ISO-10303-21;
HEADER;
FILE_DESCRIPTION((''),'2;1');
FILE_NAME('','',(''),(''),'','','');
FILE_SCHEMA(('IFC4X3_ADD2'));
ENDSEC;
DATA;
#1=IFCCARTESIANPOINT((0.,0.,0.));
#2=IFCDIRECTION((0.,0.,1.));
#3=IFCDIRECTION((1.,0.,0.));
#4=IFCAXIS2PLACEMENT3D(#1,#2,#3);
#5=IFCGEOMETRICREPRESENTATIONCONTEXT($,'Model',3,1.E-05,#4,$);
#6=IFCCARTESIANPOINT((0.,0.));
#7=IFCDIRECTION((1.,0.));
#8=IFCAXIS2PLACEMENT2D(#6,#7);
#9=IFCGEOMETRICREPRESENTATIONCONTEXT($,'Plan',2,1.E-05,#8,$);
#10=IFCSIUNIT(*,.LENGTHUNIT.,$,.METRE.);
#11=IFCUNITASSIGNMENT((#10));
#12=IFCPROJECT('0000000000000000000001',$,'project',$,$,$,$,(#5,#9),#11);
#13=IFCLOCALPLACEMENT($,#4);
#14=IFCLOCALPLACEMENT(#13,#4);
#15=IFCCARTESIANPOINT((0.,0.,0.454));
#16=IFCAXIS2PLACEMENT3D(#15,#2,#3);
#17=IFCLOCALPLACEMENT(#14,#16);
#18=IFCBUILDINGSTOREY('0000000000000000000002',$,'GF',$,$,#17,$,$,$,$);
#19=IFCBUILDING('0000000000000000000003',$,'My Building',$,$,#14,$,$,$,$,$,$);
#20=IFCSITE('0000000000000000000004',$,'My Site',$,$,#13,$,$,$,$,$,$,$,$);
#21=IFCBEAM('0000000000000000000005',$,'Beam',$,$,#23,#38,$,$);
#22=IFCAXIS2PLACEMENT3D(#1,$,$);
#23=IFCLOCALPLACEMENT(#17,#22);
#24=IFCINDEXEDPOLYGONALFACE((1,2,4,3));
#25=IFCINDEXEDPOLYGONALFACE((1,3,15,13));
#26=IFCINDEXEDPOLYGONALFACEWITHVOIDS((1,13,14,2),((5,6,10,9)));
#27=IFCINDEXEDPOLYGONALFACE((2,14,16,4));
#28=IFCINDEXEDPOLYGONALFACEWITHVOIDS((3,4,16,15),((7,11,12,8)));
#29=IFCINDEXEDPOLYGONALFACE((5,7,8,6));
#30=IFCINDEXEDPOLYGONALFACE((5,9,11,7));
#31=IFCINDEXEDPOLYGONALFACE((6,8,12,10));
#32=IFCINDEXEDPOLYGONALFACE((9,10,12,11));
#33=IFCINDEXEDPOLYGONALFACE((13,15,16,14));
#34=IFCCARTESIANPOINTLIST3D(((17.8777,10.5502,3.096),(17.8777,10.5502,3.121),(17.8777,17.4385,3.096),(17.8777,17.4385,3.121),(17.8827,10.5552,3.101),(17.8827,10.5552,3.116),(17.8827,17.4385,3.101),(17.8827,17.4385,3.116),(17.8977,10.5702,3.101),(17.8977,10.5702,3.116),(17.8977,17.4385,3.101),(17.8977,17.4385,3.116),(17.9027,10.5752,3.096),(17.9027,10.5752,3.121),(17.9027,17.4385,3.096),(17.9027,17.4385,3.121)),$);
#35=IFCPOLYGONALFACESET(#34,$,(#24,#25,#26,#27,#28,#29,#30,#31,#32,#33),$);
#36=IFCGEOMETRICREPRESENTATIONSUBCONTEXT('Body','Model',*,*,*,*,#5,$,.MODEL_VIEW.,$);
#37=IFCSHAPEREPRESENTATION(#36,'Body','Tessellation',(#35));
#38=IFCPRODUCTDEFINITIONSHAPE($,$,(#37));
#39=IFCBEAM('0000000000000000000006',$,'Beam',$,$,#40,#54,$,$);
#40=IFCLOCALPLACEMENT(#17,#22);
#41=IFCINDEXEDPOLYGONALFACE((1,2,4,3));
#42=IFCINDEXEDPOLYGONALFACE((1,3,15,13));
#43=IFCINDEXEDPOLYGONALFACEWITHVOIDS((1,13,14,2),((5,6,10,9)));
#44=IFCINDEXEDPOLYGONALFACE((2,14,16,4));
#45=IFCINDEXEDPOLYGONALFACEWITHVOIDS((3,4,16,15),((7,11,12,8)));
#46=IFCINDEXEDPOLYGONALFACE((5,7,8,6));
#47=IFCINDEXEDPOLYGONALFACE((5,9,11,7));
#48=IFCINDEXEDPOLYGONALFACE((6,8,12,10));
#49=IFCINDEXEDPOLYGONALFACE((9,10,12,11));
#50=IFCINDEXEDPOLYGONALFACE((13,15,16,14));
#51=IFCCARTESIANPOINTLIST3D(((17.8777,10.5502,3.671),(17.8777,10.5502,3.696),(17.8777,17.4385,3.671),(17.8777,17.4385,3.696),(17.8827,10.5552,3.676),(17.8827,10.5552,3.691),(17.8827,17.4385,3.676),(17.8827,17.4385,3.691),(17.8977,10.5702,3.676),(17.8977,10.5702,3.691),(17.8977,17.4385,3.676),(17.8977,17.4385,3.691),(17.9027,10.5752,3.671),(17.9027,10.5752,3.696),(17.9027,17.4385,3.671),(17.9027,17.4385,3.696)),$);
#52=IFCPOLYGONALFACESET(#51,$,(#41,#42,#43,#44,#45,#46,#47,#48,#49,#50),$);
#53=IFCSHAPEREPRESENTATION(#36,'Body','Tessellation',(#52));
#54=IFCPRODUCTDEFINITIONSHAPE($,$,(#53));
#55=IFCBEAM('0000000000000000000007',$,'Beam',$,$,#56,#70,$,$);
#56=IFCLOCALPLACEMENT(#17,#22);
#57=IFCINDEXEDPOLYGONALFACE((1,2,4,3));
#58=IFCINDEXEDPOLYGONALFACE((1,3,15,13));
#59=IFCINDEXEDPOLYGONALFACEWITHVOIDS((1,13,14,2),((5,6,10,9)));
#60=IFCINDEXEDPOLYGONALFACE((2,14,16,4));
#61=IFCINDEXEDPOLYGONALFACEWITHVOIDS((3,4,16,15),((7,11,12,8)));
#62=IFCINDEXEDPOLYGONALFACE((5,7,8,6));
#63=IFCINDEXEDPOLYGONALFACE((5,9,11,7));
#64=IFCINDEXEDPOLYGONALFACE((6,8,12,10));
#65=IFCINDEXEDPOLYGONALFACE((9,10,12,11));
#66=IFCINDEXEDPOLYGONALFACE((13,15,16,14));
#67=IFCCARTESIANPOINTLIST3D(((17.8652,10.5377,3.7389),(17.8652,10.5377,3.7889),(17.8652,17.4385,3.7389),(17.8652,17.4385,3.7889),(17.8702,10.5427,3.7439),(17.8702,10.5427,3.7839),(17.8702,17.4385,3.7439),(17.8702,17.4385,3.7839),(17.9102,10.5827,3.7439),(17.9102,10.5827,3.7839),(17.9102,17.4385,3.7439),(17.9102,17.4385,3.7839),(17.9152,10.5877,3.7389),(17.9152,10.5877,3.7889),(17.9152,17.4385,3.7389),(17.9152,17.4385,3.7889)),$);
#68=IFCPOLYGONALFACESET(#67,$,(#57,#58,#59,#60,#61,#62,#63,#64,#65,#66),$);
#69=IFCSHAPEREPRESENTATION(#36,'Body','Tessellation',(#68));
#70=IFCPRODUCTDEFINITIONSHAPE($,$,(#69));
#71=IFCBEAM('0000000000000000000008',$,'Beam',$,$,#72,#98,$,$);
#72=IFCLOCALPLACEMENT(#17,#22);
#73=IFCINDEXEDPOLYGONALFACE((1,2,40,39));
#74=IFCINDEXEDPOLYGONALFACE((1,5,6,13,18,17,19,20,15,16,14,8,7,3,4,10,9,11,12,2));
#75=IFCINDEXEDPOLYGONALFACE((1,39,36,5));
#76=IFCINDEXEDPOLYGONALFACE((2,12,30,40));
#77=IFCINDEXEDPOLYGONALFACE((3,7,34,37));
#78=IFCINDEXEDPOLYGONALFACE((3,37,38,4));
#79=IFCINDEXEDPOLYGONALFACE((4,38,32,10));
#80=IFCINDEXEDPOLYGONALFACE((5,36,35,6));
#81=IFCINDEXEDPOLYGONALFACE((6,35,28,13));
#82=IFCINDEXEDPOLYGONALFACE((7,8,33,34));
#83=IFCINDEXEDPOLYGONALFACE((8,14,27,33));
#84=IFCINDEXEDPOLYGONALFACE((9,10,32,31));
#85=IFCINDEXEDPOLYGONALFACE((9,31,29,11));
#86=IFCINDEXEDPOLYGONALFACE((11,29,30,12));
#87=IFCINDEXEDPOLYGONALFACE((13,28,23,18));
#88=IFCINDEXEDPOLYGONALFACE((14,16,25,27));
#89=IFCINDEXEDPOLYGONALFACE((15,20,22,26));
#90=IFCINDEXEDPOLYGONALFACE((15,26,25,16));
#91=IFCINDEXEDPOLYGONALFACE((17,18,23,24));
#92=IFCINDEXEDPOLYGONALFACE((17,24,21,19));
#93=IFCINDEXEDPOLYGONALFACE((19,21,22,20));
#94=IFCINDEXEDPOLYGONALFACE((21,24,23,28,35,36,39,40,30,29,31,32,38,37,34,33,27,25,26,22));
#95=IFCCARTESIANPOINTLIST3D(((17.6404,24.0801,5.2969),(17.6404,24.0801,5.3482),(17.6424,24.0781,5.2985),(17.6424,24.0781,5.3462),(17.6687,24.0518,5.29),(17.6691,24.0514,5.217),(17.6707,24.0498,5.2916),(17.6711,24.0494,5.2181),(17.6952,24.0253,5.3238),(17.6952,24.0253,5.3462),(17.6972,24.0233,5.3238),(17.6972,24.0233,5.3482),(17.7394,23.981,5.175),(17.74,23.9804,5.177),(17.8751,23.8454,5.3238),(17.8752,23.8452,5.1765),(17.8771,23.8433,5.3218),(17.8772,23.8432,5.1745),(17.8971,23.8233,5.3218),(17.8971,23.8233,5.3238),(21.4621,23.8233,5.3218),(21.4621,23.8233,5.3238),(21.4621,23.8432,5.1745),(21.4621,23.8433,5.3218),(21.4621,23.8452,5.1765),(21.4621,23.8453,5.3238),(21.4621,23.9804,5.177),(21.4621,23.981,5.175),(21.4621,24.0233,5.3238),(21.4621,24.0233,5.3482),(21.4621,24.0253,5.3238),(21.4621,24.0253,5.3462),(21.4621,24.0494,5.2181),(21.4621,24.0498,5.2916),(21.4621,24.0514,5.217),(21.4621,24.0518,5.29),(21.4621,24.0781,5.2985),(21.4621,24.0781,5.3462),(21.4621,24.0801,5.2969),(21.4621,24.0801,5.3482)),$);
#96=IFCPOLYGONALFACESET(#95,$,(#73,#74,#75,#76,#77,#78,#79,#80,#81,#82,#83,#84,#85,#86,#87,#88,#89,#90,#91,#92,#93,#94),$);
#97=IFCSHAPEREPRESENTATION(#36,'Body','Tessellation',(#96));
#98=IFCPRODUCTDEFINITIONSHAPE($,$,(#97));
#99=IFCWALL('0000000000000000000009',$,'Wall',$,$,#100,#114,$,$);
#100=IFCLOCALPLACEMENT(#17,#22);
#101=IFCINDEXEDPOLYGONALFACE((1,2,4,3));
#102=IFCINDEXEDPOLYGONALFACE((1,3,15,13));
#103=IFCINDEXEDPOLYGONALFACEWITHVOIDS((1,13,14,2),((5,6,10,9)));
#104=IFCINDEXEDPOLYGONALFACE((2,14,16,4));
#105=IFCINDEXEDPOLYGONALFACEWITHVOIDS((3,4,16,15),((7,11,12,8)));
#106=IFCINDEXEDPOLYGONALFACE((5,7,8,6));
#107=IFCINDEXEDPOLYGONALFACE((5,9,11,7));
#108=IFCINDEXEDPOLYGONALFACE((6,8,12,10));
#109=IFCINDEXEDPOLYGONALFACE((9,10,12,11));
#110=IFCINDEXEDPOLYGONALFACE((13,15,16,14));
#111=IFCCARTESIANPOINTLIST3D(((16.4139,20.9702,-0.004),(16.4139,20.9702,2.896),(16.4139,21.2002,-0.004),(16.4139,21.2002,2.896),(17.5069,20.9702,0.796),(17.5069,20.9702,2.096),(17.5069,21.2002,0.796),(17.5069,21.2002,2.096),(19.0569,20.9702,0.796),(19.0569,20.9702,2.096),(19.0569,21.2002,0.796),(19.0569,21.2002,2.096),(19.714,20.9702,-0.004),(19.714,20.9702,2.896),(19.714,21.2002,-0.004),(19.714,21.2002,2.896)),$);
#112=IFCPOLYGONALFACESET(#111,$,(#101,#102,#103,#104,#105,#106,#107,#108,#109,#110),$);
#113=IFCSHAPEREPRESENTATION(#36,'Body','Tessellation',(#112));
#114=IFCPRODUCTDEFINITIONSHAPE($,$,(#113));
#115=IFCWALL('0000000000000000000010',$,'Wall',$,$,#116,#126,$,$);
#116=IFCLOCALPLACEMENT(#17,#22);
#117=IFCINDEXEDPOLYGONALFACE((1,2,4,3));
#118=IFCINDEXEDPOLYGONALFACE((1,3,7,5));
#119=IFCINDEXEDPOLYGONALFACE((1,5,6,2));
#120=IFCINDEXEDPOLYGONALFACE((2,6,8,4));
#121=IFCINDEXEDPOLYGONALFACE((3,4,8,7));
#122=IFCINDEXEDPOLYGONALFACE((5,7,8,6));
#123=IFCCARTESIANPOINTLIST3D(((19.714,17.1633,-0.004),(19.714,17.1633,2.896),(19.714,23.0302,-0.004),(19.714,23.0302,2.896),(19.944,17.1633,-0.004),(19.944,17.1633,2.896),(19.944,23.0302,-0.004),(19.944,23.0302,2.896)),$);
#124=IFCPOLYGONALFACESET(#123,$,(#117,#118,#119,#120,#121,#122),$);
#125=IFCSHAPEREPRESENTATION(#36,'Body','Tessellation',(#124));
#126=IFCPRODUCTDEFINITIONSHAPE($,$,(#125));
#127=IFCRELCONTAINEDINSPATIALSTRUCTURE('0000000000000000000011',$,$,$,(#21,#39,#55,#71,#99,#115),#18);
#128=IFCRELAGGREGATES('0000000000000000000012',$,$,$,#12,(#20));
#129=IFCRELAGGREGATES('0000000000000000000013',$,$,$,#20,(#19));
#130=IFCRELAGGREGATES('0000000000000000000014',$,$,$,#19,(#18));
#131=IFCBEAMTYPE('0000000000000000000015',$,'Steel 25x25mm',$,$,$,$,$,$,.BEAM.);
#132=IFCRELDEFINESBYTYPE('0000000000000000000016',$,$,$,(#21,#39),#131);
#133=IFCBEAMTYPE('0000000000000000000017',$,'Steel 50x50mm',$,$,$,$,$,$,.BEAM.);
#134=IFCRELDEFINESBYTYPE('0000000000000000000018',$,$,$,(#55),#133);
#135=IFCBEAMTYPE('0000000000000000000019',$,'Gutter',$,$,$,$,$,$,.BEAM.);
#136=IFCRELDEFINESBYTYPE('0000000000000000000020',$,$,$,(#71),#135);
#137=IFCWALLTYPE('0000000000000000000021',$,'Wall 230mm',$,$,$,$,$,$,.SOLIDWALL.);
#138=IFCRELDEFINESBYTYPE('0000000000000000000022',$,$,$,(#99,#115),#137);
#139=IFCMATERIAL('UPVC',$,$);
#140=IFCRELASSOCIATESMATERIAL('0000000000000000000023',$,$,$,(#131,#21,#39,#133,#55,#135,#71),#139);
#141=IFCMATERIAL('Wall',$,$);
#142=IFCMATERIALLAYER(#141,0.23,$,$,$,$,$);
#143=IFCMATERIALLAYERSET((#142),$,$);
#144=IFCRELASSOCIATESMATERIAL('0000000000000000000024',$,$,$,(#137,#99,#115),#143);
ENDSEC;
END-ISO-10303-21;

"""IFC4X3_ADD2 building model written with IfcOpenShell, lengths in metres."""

from ifc_helpers import new_model, si_unit, frame, origin_with_axes, origin_2d_with_axis, place, context, subcontext, project, spatial, line, indexed_curve, hollow_rectangle, outline, extrude, clip, halfspace, source, transform, mapped, material, layer, layer_set, layer_usage, material_profile, profile_set, profile_usage, type_object, element, save


model = new_model("IFC4X3_ADD2")

# Units and contexts
model_context = context("Model", 3, precision=1e-05, world=origin_with_axes())
plan_context = context("Plan", 2, precision=1e-05, world=origin_2d_with_axis())
body_context_1 = subcontext(model_context, "Body", "Model", "MODEL_VIEW")
ifc_project = project(units=[si_unit("LENGTHUNIT", "METRE")], contexts=[model_context, plan_context])

# Site, building, storey
site_placement = place(None, origin_with_axes())
site = spatial("IfcSite", under=ifc_project, at=site_placement, Name="My Site")
building_placement = place(site_placement, origin_with_axes())
building = spatial("IfcBuilding", under=site, at=building_placement, Name="My Building")
storey_placement = place(building_placement, frame((0.0, 0.0, 0.454), z_axis=(0.0, 0.0, 1.0), x_axis=(1.0, 0.0, 0.0)))
storey = spatial("IfcBuildingStorey", under=building, at=storey_placement, Name="GF")

# Shared definitions
ifc_material_1 = material(Name="UPVC")

# Beams
ifc_material_profile_1 = material_profile(ifc_material_1, hollow_rectangle(XDim=0.025, YDim=0.025, WallThickness=0.005))
ifc_profile_set_1 = profile_set([ifc_material_profile_1])
ifc_profile_usage_1 = profile_usage(ifc_profile_set_1)
beam_type_1 = type_object("IfcBeamType", Name="Steel 25x25mm", PredefinedType="BEAM", material=ifc_profile_set_1)
beam_1_placement = place(storey_placement, frame((17.8902, 17.4385, 3.1085), z_axis=(0.0, -1.0, 0.0), x_axis=(1.0, 0.0, 0.0)))
element("IfcBeam", 1, at=beam_1_placement, inside=storey, type_object=beam_type_1, material=ifc_profile_usage_1, Name="Beam", context=body_context_1, shape_type="Clipping", body=[
    clip(extrude(hollow_rectangle(XDim=0.025, YDim=0.025, WallThickness=0.005), origin_with_axes(), (0.0, 0.0, 1.0), 6.8883), halfspace(frame((-0.0125, -3.5625, 6.8883), z_axis=(0.70708, 0.0, 0.707134), x_axis=(0.0, -1.0, 0.0)), False)),
])
ifc_profile_usage_2 = profile_usage(ifc_profile_set_1)
beam_2_placement = place(storey_placement, frame((17.8902, 17.4385, 3.6835), z_axis=(0.0, -1.0, 0.0), x_axis=(1.0, 0.0, 0.0)))
element("IfcBeam", 2, at=beam_2_placement, inside=storey, type_object=beam_type_1, material=ifc_profile_usage_2, Name="Beam", context=body_context_1, shape_type="Clipping", body=[
    clip(extrude(hollow_rectangle(XDim=0.025, YDim=0.025, WallThickness=0.005), origin_with_axes(), (0.0, 0.0, 1.0), 6.8883), halfspace(frame((-0.0125, -4.1375, 6.8883), z_axis=(0.70708, 0.0, 0.707134), x_axis=(0.0, -1.0, 0.0)), False)),
])
ifc_material_profile_2 = material_profile(ifc_material_1, hollow_rectangle(XDim=0.05, YDim=0.05, WallThickness=0.005))
ifc_profile_set_2 = profile_set([ifc_material_profile_2])
ifc_profile_usage_3 = profile_usage(ifc_profile_set_2)
beam_type_2 = type_object("IfcBeamType", Name="Steel 50x50mm", PredefinedType="BEAM", material=ifc_profile_set_2)
beam_3_placement = place(storey_placement, frame((17.8902, 17.4385, 3.7639), z_axis=(0.0, -1.0, 0.0), x_axis=(1.0, 0.0, 0.0)))
element("IfcBeam", 3, at=beam_3_placement, inside=storey, type_object=beam_type_2, material=ifc_profile_usage_3, Name="Beam", context=body_context_1, shape_type="Clipping", body=[
    clip(extrude(hollow_rectangle(XDim=0.05, YDim=0.05, WallThickness=0.005), origin_with_axes(), (0.0, 0.0, 1.0), 6.9008), halfspace(frame((-0.025, -4.2179, 6.9008), z_axis=(0.707107, 0.0, 0.707107), x_axis=(0.0, -1.0, 0.0)), False)),
])
ifc_material_profile_3 = material_profile(ifc_material_1, outline(indexed_curve([(0.0548, 0.1717), (0.002, 0.1717), (0.002, 0.124), (0.0303, 0.1171), (0.0307, 0.0436), (0.0996, 0.0025), (0.2349, 0.002), (0.2347, 0.1494), (0.2567, 0.1494), (0.2567, 0.1474), (0.2367, 0.1474), (0.2369, 0.0), (0.0991, 0.0005), (0.0287, 0.0425), (0.0283, 0.1155), (0.0, 0.1224), (0.0, 0.1737), (0.0568, 0.1737), (0.0568, 0.1494), (0.0548, 0.1494), (0.0548, 0.1717)])))
ifc_profile_set_3 = profile_set([ifc_material_profile_3])
ifc_profile_usage_4 = profile_usage(ifc_profile_set_3)
beam_type_3 = type_object("IfcBeamType", Name="Gutter", PredefinedType="BEAM", material=ifc_profile_set_3)
beam_4_placement = place(storey_placement, frame((21.4621, 24.0801, 5.1745), z_axis=(-1.0, 0.000001, 0.0), x_axis=(-0.000001, -1.0, 0.000001)))
element("IfcBeam", 4, at=beam_4_placement, inside=storey, type_object=beam_type_3, material=ifc_profile_usage_4, Name="Beam", context=body_context_1, shape_type="Clipping", body=[
    clip(extrude(outline(indexed_curve([(0.0548, 0.1717), (0.002, 0.1717), (0.002, 0.124), (0.0303, 0.1171), (0.0307, 0.0436), (0.0996, 0.0025), (0.2349, 0.002), (0.2347, 0.1494), (0.2567, 0.1494), (0.2567, 0.1474), (0.2367, 0.1474), (0.2369, 0.0), (0.0991, 0.0005), (0.0287, 0.0425), (0.0283, 0.1155), (0.0, 0.1224), (0.0, 0.1737), (0.0568, 0.1737), (0.0568, 0.1494), (0.0548, 0.1494), (0.0548, 0.1717)])), origin_with_axes(), (0.0, 0.0, 1.0), 3.8217), halfspace(frame((0.0, -5.6285, 3.8217), z_axis=(0.707107, 0.0, 0.707106), x_axis=(0.0, -1.0, 0.0)), False)),
])

# Wall, opening
ifc_material_2 = material(Name="Wall")
ifc_layer_1 = layer(ifc_material_2, 0.23)
ifc_layer_set_1 = layer_set([ifc_layer_1])
ifc_layer_usage_1 = layer_usage(ifc_layer_set_1, "AXIS2", "POSITIVE", 0.0)
wall_type = type_object("IfcWallType", Name="Wall 230mm", PredefinedType="SOLIDWALL", material=ifc_layer_set_1)
wall_1_placement = place(storey_placement, frame((19.714, 21.2002, -0.004), z_axis=(0.0, 0.0, 1.0), x_axis=(-1.0, 0.0, 0.0)))
wall_1 = element("IfcWall", 5, at=wall_1_placement, inside=storey, type_object=wall_type, material=ifc_layer_usage_1, Name="Wall", context=body_context_1, shape_type="SweptSolid", body=[
    extrude(outline(indexed_curve([(0.0, 0.0), (0.0, 0.23), (3.3, 0.23), (3.3, 0.0), (0.0, 0.0)], self_intersect=False)), origin_with_axes(), (0.0, 0.0, 1.0), 2.9),
])
shared_shape_1 = source(origin_with_axes(), body_context_1, "Body", "SweptSolid", [
    extrude(outline(indexed_curve([(0.0, 0.0), (1.55, 0.0), (1.55, 1.3), (0.0, 1.3)], segments=[line(1, 2, 3, 4, 1)])), frame((-0.775, -0.6, 0.0), z_axis=(0.0, -1.0, 0.0), x_axis=(1.0, 0.0, 0.0)), (0.0, 0.0, -1.0), 1.2),
])
opening_1_placement = place(wall_1_placement, frame((1.432, 0.0, 0.8), z_axis=(0.0, 0.0, 1.0), x_axis=(1.0, 0.0, 0.0)))
element("IfcOpeningElement", 6, at=opening_1_placement, cuts=wall_1, PredefinedType="OPENING", context=body_context_1, shape_type="MappedRepresentation", body=[
    mapped(shared_shape_1, transform((0.0, 0.0, 0.0), x_axis=(1.0, 0.0, 0.0), y_axis=(0.0, 1.0, 0.0), z_axis=(0.0, 0.0, 1.0), scale=1.0)),
])

# Wall
ifc_layer_usage_2 = layer_usage(ifc_layer_set_1, "AXIS2", "POSITIVE", 0.0)
wall_2_placement = place(storey_placement, frame((19.944, 17.1633, -0.004), z_axis=(0.0, 0.0, 1.0), x_axis=(0.000001, 1.0, 0.0)))
element("IfcWall", 7, at=wall_2_placement, inside=storey, type_object=wall_type, material=ifc_layer_usage_2, Name="Wall", context=body_context_1, shape_type="SweptSolid", body=[
    extrude(outline(indexed_curve([(0.0, 0.0), (0.0, 0.23), (5.8669, 0.23), (5.8669, 0.0), (0.0, 0.0)], self_intersect=False)), origin_with_axes(), (0.0, 0.0, 1.0), 2.9),
])

save(model, "model.ifc")
